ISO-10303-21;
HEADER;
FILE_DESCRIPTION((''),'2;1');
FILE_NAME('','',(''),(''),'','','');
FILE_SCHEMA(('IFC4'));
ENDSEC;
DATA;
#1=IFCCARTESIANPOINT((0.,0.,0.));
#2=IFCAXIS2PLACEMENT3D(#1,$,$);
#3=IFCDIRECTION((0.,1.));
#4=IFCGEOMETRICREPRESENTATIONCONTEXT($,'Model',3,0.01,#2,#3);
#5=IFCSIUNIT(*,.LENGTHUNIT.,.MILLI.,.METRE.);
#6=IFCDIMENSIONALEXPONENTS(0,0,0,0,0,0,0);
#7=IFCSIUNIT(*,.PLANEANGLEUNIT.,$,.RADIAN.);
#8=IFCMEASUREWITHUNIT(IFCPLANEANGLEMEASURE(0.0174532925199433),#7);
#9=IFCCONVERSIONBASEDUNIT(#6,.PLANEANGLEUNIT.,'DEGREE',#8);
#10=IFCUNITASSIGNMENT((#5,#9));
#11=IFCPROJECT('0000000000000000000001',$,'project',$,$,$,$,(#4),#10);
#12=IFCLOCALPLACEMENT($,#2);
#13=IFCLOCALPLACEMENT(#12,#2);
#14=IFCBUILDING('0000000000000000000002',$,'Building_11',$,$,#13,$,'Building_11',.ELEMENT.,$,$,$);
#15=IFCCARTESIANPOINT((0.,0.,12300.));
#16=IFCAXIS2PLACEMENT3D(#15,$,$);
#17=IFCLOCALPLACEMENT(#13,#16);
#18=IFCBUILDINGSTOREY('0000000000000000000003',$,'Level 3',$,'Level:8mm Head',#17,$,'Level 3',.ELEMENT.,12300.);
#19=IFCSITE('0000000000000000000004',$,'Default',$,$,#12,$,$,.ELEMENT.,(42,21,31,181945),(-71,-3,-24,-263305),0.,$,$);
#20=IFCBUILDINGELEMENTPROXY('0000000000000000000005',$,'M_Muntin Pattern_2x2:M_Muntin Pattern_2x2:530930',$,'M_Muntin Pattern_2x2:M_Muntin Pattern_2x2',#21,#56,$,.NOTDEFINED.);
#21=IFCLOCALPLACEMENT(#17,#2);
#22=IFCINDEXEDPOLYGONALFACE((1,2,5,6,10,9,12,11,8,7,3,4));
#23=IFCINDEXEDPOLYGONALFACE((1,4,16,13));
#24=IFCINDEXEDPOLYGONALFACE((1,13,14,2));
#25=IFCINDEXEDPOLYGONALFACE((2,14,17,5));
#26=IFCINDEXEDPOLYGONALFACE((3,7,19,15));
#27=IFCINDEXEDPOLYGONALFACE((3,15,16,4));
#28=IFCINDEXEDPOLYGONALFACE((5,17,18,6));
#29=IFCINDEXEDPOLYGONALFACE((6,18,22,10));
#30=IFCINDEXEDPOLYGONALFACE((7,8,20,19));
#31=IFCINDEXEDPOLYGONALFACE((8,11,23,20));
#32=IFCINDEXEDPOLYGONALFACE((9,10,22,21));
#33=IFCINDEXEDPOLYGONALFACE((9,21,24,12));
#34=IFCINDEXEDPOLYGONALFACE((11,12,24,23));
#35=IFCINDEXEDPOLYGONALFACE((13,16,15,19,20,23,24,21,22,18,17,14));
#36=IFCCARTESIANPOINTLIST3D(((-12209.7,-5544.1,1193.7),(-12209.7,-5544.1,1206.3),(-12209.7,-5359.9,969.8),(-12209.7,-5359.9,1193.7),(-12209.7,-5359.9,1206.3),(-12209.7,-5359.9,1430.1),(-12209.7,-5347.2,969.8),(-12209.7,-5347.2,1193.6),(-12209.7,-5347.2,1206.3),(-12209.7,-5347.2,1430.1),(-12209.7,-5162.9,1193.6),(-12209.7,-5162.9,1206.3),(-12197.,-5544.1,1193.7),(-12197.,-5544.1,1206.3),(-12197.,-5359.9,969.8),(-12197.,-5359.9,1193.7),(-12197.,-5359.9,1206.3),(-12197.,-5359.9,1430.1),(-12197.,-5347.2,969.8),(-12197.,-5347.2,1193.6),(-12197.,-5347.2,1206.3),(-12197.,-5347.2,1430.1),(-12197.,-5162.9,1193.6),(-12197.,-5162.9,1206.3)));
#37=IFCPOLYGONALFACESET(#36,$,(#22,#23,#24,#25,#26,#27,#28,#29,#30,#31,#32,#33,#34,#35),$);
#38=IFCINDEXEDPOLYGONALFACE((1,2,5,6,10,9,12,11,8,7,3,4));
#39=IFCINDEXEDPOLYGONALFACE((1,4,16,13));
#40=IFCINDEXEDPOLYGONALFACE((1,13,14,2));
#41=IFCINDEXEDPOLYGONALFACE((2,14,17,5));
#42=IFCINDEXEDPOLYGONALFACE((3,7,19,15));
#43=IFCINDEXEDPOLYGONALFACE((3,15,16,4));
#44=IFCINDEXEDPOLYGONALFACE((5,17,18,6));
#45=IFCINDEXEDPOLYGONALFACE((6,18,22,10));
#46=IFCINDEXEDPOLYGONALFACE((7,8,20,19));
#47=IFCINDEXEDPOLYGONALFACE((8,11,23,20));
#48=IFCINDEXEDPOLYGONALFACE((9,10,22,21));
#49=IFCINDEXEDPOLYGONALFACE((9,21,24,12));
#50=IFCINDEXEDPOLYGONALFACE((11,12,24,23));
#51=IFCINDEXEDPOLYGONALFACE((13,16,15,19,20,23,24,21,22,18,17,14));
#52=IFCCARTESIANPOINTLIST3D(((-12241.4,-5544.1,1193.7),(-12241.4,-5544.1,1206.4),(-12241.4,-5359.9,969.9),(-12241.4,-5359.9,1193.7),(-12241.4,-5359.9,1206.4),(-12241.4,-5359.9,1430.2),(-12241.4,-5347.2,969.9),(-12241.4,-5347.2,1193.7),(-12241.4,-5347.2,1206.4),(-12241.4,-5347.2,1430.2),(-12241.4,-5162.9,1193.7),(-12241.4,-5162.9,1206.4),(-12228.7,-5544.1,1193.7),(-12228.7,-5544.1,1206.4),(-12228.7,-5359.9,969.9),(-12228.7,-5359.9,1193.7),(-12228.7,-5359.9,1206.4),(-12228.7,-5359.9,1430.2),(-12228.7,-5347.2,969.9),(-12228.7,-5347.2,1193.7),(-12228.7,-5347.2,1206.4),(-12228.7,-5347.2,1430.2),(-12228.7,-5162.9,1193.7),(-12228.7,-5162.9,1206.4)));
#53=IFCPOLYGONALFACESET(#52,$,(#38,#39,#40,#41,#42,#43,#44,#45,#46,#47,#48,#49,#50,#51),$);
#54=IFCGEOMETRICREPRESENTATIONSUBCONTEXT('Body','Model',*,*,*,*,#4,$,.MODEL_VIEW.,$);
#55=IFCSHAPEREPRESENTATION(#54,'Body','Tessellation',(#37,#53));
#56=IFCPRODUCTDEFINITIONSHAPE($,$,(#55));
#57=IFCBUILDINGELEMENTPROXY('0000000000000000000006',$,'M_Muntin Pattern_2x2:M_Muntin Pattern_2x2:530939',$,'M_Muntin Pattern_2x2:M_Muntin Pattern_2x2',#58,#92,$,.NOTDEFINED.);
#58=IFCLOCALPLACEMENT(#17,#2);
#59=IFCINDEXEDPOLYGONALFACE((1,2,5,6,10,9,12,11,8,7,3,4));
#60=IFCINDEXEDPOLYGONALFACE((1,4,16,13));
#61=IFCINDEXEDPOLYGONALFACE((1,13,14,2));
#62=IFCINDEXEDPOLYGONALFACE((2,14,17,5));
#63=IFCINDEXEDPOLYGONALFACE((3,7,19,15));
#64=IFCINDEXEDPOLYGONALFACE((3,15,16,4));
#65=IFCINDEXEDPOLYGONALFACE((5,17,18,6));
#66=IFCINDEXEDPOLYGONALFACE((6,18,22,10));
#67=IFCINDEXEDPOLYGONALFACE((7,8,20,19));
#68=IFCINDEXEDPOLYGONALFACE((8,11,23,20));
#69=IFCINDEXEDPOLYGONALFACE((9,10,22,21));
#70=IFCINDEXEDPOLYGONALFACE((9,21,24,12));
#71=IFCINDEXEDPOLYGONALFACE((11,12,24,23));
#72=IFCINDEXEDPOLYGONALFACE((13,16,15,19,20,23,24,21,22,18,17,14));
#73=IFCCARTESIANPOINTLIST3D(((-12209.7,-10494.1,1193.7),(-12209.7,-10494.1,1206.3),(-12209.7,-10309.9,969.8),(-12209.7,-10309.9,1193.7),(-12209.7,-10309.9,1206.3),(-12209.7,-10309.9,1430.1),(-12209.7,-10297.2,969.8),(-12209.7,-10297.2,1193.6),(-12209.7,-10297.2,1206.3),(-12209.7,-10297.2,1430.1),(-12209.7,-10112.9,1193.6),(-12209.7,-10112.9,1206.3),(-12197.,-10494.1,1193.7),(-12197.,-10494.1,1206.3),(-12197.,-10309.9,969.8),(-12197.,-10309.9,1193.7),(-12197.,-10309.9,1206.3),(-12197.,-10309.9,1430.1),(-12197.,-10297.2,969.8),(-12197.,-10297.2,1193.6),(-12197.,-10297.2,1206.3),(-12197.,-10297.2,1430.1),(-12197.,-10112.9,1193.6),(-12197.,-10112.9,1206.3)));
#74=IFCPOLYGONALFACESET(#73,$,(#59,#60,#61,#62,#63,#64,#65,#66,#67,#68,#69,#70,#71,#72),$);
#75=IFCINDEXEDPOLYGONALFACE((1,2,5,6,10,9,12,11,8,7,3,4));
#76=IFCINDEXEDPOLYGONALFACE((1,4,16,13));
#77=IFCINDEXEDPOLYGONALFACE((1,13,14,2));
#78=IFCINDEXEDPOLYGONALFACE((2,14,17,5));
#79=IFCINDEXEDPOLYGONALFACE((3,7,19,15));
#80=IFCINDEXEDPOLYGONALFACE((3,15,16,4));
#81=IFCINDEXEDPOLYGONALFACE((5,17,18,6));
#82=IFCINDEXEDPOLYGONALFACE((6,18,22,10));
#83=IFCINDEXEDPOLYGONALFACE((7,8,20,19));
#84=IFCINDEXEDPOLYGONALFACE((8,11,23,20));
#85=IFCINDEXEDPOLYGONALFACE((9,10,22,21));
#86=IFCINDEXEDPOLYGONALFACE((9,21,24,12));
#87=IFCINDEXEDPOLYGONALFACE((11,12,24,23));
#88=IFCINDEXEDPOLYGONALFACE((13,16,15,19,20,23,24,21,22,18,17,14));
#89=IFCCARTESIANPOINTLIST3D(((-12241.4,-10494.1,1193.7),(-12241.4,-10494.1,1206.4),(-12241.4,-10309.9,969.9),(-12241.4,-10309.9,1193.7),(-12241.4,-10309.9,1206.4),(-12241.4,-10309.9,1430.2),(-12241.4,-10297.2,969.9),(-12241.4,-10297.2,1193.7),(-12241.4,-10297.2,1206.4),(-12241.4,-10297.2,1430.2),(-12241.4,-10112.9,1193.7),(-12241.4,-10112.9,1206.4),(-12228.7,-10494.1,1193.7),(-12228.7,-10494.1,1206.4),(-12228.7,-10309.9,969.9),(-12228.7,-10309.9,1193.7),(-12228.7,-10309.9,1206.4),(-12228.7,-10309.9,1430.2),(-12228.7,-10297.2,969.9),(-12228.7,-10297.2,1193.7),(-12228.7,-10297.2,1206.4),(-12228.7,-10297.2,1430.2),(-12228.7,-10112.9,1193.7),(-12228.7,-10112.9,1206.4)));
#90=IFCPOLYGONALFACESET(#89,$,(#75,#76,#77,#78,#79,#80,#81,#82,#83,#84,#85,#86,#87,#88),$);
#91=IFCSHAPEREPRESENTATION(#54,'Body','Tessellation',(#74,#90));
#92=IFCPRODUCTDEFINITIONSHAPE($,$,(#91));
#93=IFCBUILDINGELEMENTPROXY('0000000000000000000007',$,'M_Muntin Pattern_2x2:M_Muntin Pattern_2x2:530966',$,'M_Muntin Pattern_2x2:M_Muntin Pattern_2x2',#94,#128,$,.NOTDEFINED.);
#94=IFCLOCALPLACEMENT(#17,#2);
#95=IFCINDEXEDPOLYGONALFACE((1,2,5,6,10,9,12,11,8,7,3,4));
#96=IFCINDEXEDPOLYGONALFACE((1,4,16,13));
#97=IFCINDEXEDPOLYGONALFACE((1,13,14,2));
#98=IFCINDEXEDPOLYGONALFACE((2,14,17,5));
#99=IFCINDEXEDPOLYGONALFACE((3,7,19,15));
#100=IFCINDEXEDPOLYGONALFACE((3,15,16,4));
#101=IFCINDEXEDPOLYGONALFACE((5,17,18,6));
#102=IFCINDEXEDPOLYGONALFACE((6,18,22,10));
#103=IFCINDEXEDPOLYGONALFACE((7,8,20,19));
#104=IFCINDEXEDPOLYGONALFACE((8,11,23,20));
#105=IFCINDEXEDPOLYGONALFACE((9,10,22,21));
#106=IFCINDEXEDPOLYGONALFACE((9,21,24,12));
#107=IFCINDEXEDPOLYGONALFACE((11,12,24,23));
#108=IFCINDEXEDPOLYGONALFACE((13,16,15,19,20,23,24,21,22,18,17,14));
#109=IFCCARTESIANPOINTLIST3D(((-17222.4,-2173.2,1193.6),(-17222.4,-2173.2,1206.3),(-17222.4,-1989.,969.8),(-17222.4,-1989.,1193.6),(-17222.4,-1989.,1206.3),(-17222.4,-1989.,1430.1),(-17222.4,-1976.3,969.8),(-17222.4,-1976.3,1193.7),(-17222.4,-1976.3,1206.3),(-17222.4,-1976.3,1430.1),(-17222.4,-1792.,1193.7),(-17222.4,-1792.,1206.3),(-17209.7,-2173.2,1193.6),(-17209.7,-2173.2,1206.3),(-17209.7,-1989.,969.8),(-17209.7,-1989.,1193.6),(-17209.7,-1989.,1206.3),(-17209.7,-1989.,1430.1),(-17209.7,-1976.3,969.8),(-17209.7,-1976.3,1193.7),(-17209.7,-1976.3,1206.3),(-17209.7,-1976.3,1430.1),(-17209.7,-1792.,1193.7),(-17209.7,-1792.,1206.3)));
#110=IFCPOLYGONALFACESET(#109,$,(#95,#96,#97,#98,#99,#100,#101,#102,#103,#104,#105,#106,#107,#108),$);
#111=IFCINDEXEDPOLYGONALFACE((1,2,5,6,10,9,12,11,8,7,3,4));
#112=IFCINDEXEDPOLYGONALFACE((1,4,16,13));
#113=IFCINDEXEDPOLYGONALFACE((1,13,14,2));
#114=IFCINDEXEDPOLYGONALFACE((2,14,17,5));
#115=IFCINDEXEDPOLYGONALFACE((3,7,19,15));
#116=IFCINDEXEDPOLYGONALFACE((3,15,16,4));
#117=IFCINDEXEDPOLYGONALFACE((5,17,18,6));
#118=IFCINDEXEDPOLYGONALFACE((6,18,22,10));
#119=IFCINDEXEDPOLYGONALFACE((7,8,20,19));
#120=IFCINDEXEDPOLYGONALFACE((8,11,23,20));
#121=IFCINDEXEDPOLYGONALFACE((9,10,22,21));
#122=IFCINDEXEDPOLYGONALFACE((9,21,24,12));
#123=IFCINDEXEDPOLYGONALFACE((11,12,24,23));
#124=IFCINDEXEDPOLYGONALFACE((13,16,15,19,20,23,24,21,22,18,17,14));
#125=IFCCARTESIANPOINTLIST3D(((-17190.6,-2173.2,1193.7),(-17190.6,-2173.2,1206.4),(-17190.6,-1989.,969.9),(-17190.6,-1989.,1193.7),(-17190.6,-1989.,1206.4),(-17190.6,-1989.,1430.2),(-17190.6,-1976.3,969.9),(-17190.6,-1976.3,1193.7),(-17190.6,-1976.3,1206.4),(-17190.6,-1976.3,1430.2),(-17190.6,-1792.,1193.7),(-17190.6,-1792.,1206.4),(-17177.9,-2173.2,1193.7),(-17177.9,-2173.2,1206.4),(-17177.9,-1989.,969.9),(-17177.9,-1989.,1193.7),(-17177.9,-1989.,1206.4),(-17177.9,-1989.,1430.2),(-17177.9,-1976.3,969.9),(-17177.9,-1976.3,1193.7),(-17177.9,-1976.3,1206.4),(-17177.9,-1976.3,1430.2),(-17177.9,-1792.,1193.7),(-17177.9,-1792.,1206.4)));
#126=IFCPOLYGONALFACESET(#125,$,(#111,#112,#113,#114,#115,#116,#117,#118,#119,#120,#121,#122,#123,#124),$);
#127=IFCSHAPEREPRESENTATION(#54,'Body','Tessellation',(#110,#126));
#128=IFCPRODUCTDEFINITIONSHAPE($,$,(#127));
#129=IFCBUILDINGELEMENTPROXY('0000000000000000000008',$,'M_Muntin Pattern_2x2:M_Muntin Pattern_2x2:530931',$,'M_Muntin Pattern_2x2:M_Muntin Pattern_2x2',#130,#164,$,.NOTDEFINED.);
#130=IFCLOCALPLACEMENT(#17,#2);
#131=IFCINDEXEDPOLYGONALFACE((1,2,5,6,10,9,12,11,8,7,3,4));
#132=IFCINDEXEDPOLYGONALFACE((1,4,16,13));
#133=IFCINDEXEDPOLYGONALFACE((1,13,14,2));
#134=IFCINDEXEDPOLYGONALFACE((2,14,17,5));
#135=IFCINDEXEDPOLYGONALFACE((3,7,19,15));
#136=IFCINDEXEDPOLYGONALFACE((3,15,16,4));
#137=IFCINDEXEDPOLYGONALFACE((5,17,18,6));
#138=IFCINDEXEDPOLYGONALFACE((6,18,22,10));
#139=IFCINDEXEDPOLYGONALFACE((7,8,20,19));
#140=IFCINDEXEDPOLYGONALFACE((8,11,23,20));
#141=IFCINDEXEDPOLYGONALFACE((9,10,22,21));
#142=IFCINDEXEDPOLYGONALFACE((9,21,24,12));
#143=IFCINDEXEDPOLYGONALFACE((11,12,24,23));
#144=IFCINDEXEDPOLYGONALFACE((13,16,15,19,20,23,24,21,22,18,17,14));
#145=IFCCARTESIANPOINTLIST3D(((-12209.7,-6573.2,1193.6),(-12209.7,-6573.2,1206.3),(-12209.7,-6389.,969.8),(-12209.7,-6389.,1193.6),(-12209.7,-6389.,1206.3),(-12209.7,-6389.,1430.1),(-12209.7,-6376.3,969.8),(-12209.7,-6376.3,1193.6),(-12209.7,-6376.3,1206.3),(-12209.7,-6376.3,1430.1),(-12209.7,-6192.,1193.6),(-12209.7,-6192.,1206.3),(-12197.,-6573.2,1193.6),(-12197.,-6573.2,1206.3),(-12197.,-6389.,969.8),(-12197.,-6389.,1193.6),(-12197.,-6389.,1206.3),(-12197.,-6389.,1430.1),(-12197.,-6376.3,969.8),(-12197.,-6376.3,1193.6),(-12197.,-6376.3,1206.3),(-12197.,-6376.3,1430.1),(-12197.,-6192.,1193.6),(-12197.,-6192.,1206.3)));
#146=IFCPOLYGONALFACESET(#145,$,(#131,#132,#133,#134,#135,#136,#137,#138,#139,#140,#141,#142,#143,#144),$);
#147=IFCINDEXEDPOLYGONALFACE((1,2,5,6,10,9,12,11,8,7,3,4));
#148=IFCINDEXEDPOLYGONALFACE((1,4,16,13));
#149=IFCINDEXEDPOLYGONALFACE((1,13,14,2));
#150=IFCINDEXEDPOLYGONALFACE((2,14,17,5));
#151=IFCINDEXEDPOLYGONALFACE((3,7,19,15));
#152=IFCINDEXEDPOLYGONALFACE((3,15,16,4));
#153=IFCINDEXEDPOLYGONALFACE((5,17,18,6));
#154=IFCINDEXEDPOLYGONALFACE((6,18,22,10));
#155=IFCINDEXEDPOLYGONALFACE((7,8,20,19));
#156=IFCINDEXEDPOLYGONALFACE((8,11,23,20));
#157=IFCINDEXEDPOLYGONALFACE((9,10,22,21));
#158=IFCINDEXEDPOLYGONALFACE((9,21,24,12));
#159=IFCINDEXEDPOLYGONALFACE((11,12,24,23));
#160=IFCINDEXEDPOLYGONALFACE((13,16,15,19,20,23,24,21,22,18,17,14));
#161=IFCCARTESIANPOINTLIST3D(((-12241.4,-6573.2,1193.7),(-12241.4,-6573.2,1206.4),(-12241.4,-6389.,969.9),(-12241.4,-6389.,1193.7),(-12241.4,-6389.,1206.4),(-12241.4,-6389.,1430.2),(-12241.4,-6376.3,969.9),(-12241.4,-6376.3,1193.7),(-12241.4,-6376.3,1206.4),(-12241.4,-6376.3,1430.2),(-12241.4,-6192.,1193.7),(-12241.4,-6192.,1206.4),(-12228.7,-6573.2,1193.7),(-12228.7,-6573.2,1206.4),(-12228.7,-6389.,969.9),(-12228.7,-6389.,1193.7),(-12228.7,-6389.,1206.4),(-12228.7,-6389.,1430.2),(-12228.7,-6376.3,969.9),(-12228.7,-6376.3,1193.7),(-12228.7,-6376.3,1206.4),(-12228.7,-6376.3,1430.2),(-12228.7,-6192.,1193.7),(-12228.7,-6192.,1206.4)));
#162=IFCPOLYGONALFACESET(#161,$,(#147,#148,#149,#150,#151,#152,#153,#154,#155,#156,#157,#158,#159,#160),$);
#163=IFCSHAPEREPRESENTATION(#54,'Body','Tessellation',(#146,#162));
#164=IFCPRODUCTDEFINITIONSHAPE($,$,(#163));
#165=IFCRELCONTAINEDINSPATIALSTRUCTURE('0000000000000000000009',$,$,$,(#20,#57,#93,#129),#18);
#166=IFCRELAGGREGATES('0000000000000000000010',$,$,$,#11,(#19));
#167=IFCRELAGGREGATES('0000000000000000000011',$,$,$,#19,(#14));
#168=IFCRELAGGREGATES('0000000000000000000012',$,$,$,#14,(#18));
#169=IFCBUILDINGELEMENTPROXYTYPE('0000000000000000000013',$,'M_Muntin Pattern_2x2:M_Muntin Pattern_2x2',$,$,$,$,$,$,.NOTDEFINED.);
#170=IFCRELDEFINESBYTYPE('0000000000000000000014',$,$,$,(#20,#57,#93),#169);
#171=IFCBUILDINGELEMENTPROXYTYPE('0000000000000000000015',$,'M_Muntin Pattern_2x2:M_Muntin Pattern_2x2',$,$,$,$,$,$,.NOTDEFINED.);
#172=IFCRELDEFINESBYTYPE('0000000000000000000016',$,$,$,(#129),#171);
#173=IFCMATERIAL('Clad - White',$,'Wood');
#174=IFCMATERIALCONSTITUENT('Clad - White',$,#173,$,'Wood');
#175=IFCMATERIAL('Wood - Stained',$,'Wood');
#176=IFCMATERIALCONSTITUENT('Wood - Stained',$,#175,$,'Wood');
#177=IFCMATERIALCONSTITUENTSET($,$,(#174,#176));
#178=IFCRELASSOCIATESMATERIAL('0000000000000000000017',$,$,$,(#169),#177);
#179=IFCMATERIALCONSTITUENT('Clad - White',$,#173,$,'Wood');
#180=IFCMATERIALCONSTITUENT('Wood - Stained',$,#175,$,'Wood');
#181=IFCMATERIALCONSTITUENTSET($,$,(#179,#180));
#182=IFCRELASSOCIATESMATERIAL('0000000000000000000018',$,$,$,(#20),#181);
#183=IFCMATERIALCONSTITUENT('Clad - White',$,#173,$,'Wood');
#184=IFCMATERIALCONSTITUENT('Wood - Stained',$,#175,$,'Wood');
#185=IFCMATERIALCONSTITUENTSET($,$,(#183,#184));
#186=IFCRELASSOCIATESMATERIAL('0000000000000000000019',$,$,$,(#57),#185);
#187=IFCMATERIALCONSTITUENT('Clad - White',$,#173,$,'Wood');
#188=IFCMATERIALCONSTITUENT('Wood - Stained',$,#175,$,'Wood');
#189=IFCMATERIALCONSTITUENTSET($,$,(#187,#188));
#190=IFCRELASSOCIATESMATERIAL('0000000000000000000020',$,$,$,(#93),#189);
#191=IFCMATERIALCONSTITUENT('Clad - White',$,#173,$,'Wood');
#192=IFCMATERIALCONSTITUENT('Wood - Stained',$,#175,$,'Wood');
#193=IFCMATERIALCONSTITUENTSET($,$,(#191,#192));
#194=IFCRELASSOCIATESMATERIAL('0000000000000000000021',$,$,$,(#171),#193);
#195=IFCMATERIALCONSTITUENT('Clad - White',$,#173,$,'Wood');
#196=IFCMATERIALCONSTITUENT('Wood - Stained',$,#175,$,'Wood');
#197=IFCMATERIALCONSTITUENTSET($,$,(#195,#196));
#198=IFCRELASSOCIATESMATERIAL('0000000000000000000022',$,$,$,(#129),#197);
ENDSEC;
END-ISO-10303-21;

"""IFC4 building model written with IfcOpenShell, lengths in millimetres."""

from ifc_helpers import new_model, entity, si_unit, converted_unit, direction, frame, origin, place, context, subcontext, project, spatial, indexed_curve, outline, extrude, source, transform, mapped, material, constituent, constituent_set, type_object, type_shapes, element, save


model = new_model("IFC4")

# Units and contexts
model_context = context("Model", 3, precision=0.01, world=origin(), true_north=direction((0.0, 1.0)))
body_context = subcontext(model_context, "Body", "Model", "MODEL_VIEW")
ifc_project = project(units=[si_unit("LENGTHUNIT", "METRE", prefix="MILLI"), converted_unit("PLANEANGLEUNIT", "DEGREE", entity("IfcPlaneAngleMeasure", 0.0174532925199433), si_unit("PLANEANGLEUNIT", "RADIAN"), dimensions=[0, 0, 0, 0, 0, 0, 0])], contexts=[model_context])

# Site, building, storey
site_placement = place(None, origin())
site = spatial("IfcSite", under=ifc_project, at=site_placement, Name="Default", CompositionType="ELEMENT", RefLatitude=(42, 21, 31, 181945), RefLongitude=(-71, -3, -24, -263305), RefElevation=0.0)
building_placement = place(site_placement, origin())
building = spatial("IfcBuilding", under=site, at=building_placement, Name="Building_11", LongName="Building_11", CompositionType="ELEMENT")
storey_placement = place(building_placement, frame((0.0, 0.0, 12300.0)))
storey = spatial("IfcBuildingStorey", under=building, at=storey_placement, Name="Level 3", ObjectType="Level:8mm Head", LongName="Level 3", CompositionType="ELEMENT", Elevation=12300.0)

# Building element proxies
ifc_material_1 = material(Name="Clad - White", Category="Wood")
ifc_constituent_1 = constituent(ifc_material_1, Name="Clad - White", Category="Wood")
ifc_material_2 = material(Name="Wood - Stained", Category="Wood")
ifc_constituent_2 = constituent(ifc_material_2, Name="Wood - Stained", Category="Wood")
ifc_constituent_set_1 = constituent_set(constituents=[ifc_constituent_1, ifc_constituent_2])
ifc_constituent_3 = constituent(ifc_material_1, Name="Clad - White", Category="Wood")
ifc_constituent_4 = constituent(ifc_material_2, Name="Wood - Stained", Category="Wood")
ifc_constituent_set_2 = constituent_set(constituents=[ifc_constituent_3, ifc_constituent_4])
building_element_proxy_type_1 = type_object("IfcBuildingElementProxyType", Name="M_Muntin Pattern_2x2:M_Muntin Pattern_2x2", PredefinedType="NOTDEFINED", material=ifc_constituent_set_2)
shared_shape_1 = source(origin(), body_context, "Body", "SweptSolid", [
    extrude(outline(indexed_curve([(6.4, -6.4), (230.1, -6.4), (230.1, 6.3), (6.4, 6.3), (6.4, 190.6), (-6.3, 190.6), (-6.3, 6.3), (-230.2, 6.3), (-230.2, -6.4), (-6.3, -6.4), (-6.3, -190.6), (6.4, -190.6), (6.4, -6.4)], self_intersect=False)), frame((0.0, 9.5, 230.1), z_axis=(0.0, 1.0, 0.0), x_axis=(0.0, 0.0, 1.0)), (0.0, 0.0, 1.0), 12.7),
    extrude(outline(indexed_curve([(6.4, -6.4), (230.2, -6.4), (230.2, 6.3), (6.4, 6.3), (6.4, 190.6), (-6.3, 190.6), (-6.3, 6.3), (-230.2, 6.3), (-230.2, -6.4), (-6.3, -6.4), (-6.3, -190.6), (6.4, -190.6), (6.4, -6.4)], self_intersect=False)), frame((0.0, -22.2, 230.2), z_axis=(0.0, 1.0, 0.0), x_axis=(0.0, 0.0, 1.0)), (0.0, 0.0, 1.0), 12.7),
])
type_shapes(building_element_proxy_type_1, [shared_shape_1])
proxy_1_placement = place(storey_placement, frame((-12219.2, -5353.5, 969.9), z_axis=(0.0, 0.0, 1.0), x_axis=(0.0, -1.0, 0.0)))
element("IfcBuildingElementProxy", 1, at=proxy_1_placement, inside=storey, type_object=building_element_proxy_type_1, material=ifc_constituent_set_1, Name="M_Muntin Pattern_2x2:M_Muntin Pattern_2x2:530930", ObjectType="M_Muntin Pattern_2x2:M_Muntin Pattern_2x2", PredefinedType="NOTDEFINED", context=body_context, shape_type="MappedRepresentation", body=[
    mapped(shared_shape_1, transform((0.0, 0.0, 0.0), scale=1.0)),
])
ifc_constituent_5 = constituent(ifc_material_1, Name="Clad - White", Category="Wood")
ifc_constituent_6 = constituent(ifc_material_2, Name="Wood - Stained", Category="Wood")
ifc_constituent_set_3 = constituent_set(constituents=[ifc_constituent_5, ifc_constituent_6])
proxy_2_placement = place(storey_placement, frame((-12219.2, -10303.5, 969.9), z_axis=(0.0, 0.0, 1.0), x_axis=(0.0, -1.0, 0.0)))
element("IfcBuildingElementProxy", 2, at=proxy_2_placement, inside=storey, type_object=building_element_proxy_type_1, material=ifc_constituent_set_3, Name="M_Muntin Pattern_2x2:M_Muntin Pattern_2x2:530939", ObjectType="M_Muntin Pattern_2x2:M_Muntin Pattern_2x2", PredefinedType="NOTDEFINED", context=body_context, shape_type="MappedRepresentation", body=[
    mapped(shared_shape_1, transform((0.0, 0.0, 0.0), scale=1.0)),
])
ifc_constituent_7 = constituent(ifc_material_1, Name="Clad - White", Category="Wood")
ifc_constituent_8 = constituent(ifc_material_2, Name="Wood - Stained", Category="Wood")
ifc_constituent_set_4 = constituent_set(constituents=[ifc_constituent_7, ifc_constituent_8])
proxy_3_placement = place(storey_placement, frame((-17200.2, -1982.6, 969.9), z_axis=(0.0, 0.0, 1.0), x_axis=(0.0, 1.0, 0.0)))
element("IfcBuildingElementProxy", 3, at=proxy_3_placement, inside=storey, type_object=building_element_proxy_type_1, material=ifc_constituent_set_4, Name="M_Muntin Pattern_2x2:M_Muntin Pattern_2x2:530966", ObjectType="M_Muntin Pattern_2x2:M_Muntin Pattern_2x2", PredefinedType="NOTDEFINED", context=body_context, shape_type="MappedRepresentation", body=[
    mapped(shared_shape_1, transform((0.0, 0.0, 0.0), scale=1.0)),
])
ifc_constituent_9 = constituent(ifc_material_1, Name="Clad - White", Category="Wood")
ifc_constituent_10 = constituent(ifc_material_2, Name="Wood - Stained", Category="Wood")
ifc_constituent_set_5 = constituent_set(constituents=[ifc_constituent_9, ifc_constituent_10])
ifc_constituent_11 = constituent(ifc_material_1, Name="Clad - White", Category="Wood")
ifc_constituent_12 = constituent(ifc_material_2, Name="Wood - Stained", Category="Wood")
ifc_constituent_set_6 = constituent_set(constituents=[ifc_constituent_11, ifc_constituent_12])
building_element_proxy_type_2 = type_object("IfcBuildingElementProxyType", Name="M_Muntin Pattern_2x2:M_Muntin Pattern_2x2", PredefinedType="NOTDEFINED", material=ifc_constituent_set_6)
shared_shape_2 = source(origin(), body_context, "Body", "SweptSolid", [
    extrude(outline(indexed_curve([(6.4, -6.4), (230.1, -6.4), (230.1, 6.3), (6.4, 6.3), (6.4, 190.6), (-6.3, 190.6), (-6.3, 6.3), (-230.2, 6.3), (-230.2, -6.4), (-6.3, -6.4), (-6.3, -190.6), (6.4, -190.6), (6.4, -6.4)], self_intersect=False)), frame((0.0, -22.2, 230.1), z_axis=(0.0, 1.0, 0.0), x_axis=(0.0, 0.0, 1.0)), (0.0, 0.0, 1.0), 12.7),
    extrude(outline(indexed_curve([(6.4, -6.4), (230.2, -6.4), (230.2, 6.3), (6.4, 6.3), (6.4, 190.6), (-6.3, 190.6), (-6.3, 6.3), (-230.2, 6.3), (-230.2, -6.4), (-6.3, -6.4), (-6.3, -190.6), (6.4, -190.6), (6.4, -6.4)], self_intersect=False)), frame((0.0, 9.5, 230.2), z_axis=(0.0, 1.0, 0.0), x_axis=(0.0, 0.0, 1.0)), (0.0, 0.0, 1.0), 12.7),
])
type_shapes(building_element_proxy_type_2, [shared_shape_2])
proxy_4_placement = place(storey_placement, frame((-12219.2, -6382.6, 969.9), z_axis=(0.0, 0.0, 1.0), x_axis=(0.0, 1.0, 0.0)))
element("IfcBuildingElementProxy", 4, at=proxy_4_placement, inside=storey, type_object=building_element_proxy_type_2, material=ifc_constituent_set_5, Name="M_Muntin Pattern_2x2:M_Muntin Pattern_2x2:530931", ObjectType="M_Muntin Pattern_2x2:M_Muntin Pattern_2x2", PredefinedType="NOTDEFINED", context=body_context, shape_type="MappedRepresentation", body=[
    mapped(shared_shape_2, transform((0.0, 0.0, 0.0), scale=1.0)),
])

save(model, "model.ifc")
